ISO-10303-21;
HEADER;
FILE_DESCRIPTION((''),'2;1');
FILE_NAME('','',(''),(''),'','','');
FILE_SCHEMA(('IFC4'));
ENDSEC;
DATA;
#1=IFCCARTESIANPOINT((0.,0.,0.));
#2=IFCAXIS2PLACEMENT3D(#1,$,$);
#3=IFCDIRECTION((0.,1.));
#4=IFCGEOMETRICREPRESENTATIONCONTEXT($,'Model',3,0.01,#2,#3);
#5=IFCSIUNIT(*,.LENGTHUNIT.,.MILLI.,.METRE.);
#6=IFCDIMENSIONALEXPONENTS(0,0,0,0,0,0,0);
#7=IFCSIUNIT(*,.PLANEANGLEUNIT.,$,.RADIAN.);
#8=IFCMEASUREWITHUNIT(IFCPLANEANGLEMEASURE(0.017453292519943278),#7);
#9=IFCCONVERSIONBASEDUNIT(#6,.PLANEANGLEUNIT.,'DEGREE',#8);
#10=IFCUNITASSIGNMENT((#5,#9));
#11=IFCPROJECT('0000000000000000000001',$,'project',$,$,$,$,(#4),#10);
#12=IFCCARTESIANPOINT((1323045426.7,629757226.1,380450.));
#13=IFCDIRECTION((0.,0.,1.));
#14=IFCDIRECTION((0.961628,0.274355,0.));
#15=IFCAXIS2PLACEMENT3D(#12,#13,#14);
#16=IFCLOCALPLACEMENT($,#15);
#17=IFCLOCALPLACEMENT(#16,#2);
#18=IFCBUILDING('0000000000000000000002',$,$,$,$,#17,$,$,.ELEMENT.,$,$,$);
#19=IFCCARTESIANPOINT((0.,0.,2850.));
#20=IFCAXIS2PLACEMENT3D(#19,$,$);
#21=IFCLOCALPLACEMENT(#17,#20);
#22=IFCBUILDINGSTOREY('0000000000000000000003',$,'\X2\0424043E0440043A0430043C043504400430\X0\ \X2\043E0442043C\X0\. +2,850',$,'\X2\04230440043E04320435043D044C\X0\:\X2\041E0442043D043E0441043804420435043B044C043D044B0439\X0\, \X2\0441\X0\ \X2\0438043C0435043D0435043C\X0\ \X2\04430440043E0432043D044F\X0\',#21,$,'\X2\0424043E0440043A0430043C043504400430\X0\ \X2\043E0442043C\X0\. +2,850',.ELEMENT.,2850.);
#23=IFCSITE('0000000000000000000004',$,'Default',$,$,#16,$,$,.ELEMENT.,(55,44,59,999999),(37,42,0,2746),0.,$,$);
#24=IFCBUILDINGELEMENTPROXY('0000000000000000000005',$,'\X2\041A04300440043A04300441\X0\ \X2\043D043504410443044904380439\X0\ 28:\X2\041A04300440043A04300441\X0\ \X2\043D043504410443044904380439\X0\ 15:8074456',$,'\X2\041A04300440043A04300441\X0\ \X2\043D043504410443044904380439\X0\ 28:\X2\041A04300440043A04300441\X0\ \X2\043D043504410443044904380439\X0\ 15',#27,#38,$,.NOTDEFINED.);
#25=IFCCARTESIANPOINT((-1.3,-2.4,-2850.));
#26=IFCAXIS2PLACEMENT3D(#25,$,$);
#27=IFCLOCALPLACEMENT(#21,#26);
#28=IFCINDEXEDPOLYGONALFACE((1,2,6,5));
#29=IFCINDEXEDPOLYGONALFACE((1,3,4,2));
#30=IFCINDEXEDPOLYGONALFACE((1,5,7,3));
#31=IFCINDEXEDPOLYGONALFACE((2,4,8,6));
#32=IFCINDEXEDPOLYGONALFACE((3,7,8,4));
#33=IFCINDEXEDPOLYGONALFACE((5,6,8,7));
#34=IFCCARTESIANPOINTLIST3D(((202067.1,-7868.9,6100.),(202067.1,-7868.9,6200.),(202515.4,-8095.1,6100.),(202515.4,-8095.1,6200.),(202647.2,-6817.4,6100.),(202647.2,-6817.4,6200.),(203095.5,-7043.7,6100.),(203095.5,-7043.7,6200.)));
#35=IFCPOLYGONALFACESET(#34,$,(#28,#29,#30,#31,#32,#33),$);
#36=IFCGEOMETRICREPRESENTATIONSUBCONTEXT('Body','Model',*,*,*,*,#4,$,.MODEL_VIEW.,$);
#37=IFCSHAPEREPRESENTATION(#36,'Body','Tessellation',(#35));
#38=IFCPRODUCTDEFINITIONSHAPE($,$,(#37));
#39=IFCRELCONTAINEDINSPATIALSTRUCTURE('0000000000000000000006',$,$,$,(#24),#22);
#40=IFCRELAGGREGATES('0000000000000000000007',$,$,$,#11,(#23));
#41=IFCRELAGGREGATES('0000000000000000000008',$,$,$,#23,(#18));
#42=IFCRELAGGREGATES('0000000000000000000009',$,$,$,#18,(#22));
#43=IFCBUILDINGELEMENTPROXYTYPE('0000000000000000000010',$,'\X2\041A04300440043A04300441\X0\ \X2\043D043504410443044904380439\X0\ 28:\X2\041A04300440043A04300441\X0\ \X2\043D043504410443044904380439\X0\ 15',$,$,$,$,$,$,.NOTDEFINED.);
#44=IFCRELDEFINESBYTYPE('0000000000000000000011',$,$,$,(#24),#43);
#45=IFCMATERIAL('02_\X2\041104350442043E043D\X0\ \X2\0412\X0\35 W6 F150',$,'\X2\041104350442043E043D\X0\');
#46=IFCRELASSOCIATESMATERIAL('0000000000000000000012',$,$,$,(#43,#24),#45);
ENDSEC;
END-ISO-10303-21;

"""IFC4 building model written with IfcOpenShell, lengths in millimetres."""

from ifc_helpers import new_model, entity, si_unit, converted_unit, direction, frame, origin, place, context, subcontext, project, spatial, indexed_curve, outline, extrude, source, transform, mapped, material, type_object, type_shapes, element, save


model = new_model("IFC4")

# Units and contexts
model_context = context("Model", 3, precision=0.01, world=origin(), true_north=direction((0.0, 1.0)))
body_context = subcontext(model_context, "Body", "Model", "MODEL_VIEW")
ifc_project = project(units=[si_unit("LENGTHUNIT", "METRE", prefix="MILLI"), converted_unit("PLANEANGLEUNIT", "DEGREE", entity("IfcPlaneAngleMeasure", 0.017453292519943278), si_unit("PLANEANGLEUNIT", "RADIAN"), dimensions=[0, 0, 0, 0, 0, 0, 0])], contexts=[model_context])

# Site, building, storey
site_placement = place(None, frame((1323045426.7, 629757226.1, 380450.0), z_axis=(0.0, 0.0, 1.0), x_axis=(0.961628, 0.274355, 0.0)))
site = spatial("IfcSite", under=ifc_project, at=site_placement, Name="Default", CompositionType="ELEMENT", RefLatitude=(55, 44, 59, 999999), RefLongitude=(37, 42, 0, 2746), RefElevation=0.0)
building_placement = place(site_placement, origin())
building = spatial("IfcBuilding", under=site, at=building_placement, CompositionType="ELEMENT")
storey_placement = place(building_placement, frame((0.0, 0.0, 2850.0)))
storey = spatial("IfcBuildingStorey", under=building, at=storey_placement, Name="Форкамера отм. +2,850", ObjectType="Уровень:Относительный, с именем уровня", LongName="Форкамера отм. +2,850", CompositionType="ELEMENT", Elevation=2850.0)

# Building element proxy
ifc_material = material(Name="02_Бетон В35 W6 F150", Category="Бетон")
building_element_proxy_type_1 = type_object("IfcBuildingElementProxyType", Name="Каркас несущий 28:Каркас несущий 15", PredefinedType="NOTDEFINED", material=ifc_material)
shared_shape_1 = source(origin(), body_context, "Body", "SweptSolid", [
    extrude(outline(indexed_curve([(-591.2, -250.9), (609.7, -250.9), (591.2, 250.9), (-609.7, 250.9), (-591.2, -250.9)], self_intersect=False)), frame((202581.3, -7456.3, 6100.0), z_axis=(0.0, 0.0, 1.0), x_axis=(-0.483055, -0.87559, 0.0)), (0.0, 0.0, 1.0), 100.0),
])
type_shapes(building_element_proxy_type_1, [shared_shape_1])
proxy_1_placement = place(storey_placement, frame((-1.3, -2.4, -2850.0)))
element("IfcBuildingElementProxy", 1, at=proxy_1_placement, inside=storey, type_object=building_element_proxy_type_1, material=ifc_material, Name="Каркас несущий 28:Каркас несущий 15:8074456", ObjectType="Каркас несущий 28:Каркас несущий 15", PredefinedType="NOTDEFINED", context=body_context, shape_type="MappedRepresentation", body=[
    mapped(shared_shape_1, transform((0.0, 0.0, 0.0), scale=1.0)),
])

save(model, "model.ifc")
